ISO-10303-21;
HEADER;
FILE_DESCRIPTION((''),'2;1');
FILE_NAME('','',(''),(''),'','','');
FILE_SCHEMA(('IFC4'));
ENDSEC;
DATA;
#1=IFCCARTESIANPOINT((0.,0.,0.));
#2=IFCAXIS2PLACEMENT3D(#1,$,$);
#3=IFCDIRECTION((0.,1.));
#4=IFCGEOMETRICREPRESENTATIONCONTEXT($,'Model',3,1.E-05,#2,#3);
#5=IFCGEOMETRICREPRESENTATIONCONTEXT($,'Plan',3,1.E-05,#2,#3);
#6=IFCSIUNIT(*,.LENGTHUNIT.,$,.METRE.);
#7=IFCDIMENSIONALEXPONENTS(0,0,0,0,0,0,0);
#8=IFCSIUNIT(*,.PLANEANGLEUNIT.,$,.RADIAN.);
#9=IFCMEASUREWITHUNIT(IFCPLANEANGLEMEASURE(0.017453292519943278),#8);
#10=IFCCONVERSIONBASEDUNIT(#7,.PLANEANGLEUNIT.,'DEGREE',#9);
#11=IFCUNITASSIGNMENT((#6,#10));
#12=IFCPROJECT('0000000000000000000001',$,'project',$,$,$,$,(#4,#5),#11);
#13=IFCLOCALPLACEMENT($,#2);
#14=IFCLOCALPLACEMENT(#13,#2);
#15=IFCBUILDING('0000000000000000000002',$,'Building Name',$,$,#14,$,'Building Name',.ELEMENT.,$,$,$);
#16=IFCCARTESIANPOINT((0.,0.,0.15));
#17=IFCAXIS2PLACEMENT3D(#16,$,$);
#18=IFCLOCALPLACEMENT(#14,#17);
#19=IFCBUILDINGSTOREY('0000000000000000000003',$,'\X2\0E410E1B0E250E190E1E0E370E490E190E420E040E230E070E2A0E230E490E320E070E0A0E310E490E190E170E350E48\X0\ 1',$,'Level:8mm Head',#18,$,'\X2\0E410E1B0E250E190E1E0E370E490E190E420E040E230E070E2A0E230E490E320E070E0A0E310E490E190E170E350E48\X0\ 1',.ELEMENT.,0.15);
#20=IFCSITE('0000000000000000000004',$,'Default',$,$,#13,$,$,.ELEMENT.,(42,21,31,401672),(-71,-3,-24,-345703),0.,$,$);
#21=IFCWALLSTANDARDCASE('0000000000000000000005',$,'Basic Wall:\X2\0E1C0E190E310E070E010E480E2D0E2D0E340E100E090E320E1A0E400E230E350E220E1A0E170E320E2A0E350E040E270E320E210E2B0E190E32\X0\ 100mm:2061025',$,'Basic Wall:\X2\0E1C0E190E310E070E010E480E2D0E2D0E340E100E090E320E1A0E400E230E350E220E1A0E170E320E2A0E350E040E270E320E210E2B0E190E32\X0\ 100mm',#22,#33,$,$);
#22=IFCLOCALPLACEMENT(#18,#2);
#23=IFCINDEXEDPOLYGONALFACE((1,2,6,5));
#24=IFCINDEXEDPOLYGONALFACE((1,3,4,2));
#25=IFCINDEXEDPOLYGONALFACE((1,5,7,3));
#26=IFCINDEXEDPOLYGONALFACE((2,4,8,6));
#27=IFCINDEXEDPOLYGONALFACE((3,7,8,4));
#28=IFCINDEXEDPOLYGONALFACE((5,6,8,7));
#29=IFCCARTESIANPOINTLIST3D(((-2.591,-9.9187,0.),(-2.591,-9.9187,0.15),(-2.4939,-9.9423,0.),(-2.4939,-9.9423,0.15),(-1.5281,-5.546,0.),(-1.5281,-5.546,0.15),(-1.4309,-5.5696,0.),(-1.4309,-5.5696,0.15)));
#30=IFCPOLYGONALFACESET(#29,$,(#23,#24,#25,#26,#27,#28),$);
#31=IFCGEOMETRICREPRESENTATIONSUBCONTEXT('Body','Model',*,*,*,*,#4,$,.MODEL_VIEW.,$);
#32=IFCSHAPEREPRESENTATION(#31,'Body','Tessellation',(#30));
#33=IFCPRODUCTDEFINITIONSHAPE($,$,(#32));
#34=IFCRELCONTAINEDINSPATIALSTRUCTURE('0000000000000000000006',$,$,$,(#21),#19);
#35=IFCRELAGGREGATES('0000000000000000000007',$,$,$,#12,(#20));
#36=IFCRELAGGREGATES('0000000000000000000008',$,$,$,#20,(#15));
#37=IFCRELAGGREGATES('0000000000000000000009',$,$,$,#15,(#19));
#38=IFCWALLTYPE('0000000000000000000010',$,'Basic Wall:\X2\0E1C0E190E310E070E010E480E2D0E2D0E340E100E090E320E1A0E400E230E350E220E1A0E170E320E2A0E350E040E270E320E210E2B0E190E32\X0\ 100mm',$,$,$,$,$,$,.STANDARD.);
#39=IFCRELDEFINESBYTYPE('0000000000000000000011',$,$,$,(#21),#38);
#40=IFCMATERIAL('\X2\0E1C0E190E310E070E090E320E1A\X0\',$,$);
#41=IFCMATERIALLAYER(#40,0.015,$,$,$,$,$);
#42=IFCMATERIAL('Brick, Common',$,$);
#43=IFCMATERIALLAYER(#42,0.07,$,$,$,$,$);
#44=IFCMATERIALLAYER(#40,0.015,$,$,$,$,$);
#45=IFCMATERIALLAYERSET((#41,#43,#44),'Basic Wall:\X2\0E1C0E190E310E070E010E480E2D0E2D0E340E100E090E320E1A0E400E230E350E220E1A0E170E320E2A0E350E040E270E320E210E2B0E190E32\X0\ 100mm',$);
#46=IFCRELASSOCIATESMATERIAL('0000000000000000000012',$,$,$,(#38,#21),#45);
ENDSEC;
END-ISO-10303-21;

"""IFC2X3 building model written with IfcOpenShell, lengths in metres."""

from ifc_helpers import new_model, entity, si_unit, converted_unit, direction, frame, frame_2d, origin, place, context, subcontext, project, spatial, rectangle, extrude, clip, halfspace, material, layer, layer_set, layer_usage, type_object, element, save


model = new_model("IFC2X3")

# Units and contexts
model_context = context("Model", 3, precision=1e-05, world=origin(), true_north=direction((0.0, 1.0)))
plan_context = context("Plan", 3, precision=1e-05, world=origin(), true_north=direction((0.0, 1.0)))
body_context = subcontext(model_context, "Body", "Model", "MODEL_VIEW")
ifc_project = project(units=[si_unit("LENGTHUNIT", "METRE"), converted_unit("PLANEANGLEUNIT", "DEGREE", entity("IfcPlaneAngleMeasure", 0.017453292519943278), si_unit("PLANEANGLEUNIT", "RADIAN"), dimensions=[0, 0, 0, 0, 0, 0, 0])], contexts=[model_context, plan_context])

# Site, building, storey
site_placement = place(None, origin())
site = spatial("IfcSite", under=ifc_project, at=site_placement, Name="Default", CompositionType="ELEMENT", RefLatitude=(42, 21, 31, 401672), RefLongitude=(-71, -3, -24, -345703), RefElevation=0.0)
building_placement = place(site_placement, origin())
building = spatial("IfcBuilding", under=site, at=building_placement, Name="Building Name", LongName="Building Name", CompositionType="ELEMENT")
storey_placement = place(building_placement, frame((0.0, 0.0, 0.15)))
storey = spatial("IfcBuildingStorey", under=building, at=storey_placement, Name="แปลนพื้นโครงสร้างชั้นที่ 1", ObjectType="Level:8mm Head", LongName="แปลนพื้นโครงสร้างชั้นที่ 1", CompositionType="ELEMENT", Elevation=0.15)

# Wall
ifc_material_1 = material(Name="ผนังฉาบ")
ifc_layer_1 = layer(ifc_material_1, 0.015)
ifc_material_2 = material(Name="Brick, Common")
ifc_layer_2 = layer(ifc_material_2, 0.07)
ifc_layer_3 = layer(ifc_material_1, 0.015)
ifc_layer_set_1 = layer_set([ifc_layer_1, ifc_layer_2, ifc_layer_3], Name="Basic Wall:ผนังก่ออิฐฉาบเรียบทาสีความหนา 100mm")
wall_type_1 = type_object("IfcWallType", Name="Basic Wall:ผนังก่ออิฐฉาบเรียบทาสีความหนา 100mm", PredefinedType="STANDARD", material=ifc_layer_set_1)
ifc_layer_usage_1 = layer_usage(ifc_layer_set_1, "AXIS2", "POSITIVE", -0.05)
wall_1_placement = place(storey_placement, frame((-1.4795, -5.5578, 0.0), z_axis=(0.0, 0.0, 1.0), x_axis=(-0.236201, -0.971704, 0.0)))
element("IfcWallStandardCase", 1, at=wall_1_placement, inside=storey, type_object=wall_type_1, material=ifc_layer_usage_1, Name="Basic Wall:ผนังก่ออิฐฉาบเรียบทาสีความหนา 100mm:2061025", ObjectType="Basic Wall:ผนังก่ออิฐฉาบเรียบทาสีความหนา 100mm", context=body_context, shape_type="Clipping", body=[
    clip(extrude(rectangle(XDim=4.5, YDim=0.1, at=frame_2d((2.25, 0.0), x_axis=(-1.0, 0.0))), origin(), (0.0, 0.0, 1.0), 0.15), halfspace(origin(), True)),
])

save(model, "model.ifc")
